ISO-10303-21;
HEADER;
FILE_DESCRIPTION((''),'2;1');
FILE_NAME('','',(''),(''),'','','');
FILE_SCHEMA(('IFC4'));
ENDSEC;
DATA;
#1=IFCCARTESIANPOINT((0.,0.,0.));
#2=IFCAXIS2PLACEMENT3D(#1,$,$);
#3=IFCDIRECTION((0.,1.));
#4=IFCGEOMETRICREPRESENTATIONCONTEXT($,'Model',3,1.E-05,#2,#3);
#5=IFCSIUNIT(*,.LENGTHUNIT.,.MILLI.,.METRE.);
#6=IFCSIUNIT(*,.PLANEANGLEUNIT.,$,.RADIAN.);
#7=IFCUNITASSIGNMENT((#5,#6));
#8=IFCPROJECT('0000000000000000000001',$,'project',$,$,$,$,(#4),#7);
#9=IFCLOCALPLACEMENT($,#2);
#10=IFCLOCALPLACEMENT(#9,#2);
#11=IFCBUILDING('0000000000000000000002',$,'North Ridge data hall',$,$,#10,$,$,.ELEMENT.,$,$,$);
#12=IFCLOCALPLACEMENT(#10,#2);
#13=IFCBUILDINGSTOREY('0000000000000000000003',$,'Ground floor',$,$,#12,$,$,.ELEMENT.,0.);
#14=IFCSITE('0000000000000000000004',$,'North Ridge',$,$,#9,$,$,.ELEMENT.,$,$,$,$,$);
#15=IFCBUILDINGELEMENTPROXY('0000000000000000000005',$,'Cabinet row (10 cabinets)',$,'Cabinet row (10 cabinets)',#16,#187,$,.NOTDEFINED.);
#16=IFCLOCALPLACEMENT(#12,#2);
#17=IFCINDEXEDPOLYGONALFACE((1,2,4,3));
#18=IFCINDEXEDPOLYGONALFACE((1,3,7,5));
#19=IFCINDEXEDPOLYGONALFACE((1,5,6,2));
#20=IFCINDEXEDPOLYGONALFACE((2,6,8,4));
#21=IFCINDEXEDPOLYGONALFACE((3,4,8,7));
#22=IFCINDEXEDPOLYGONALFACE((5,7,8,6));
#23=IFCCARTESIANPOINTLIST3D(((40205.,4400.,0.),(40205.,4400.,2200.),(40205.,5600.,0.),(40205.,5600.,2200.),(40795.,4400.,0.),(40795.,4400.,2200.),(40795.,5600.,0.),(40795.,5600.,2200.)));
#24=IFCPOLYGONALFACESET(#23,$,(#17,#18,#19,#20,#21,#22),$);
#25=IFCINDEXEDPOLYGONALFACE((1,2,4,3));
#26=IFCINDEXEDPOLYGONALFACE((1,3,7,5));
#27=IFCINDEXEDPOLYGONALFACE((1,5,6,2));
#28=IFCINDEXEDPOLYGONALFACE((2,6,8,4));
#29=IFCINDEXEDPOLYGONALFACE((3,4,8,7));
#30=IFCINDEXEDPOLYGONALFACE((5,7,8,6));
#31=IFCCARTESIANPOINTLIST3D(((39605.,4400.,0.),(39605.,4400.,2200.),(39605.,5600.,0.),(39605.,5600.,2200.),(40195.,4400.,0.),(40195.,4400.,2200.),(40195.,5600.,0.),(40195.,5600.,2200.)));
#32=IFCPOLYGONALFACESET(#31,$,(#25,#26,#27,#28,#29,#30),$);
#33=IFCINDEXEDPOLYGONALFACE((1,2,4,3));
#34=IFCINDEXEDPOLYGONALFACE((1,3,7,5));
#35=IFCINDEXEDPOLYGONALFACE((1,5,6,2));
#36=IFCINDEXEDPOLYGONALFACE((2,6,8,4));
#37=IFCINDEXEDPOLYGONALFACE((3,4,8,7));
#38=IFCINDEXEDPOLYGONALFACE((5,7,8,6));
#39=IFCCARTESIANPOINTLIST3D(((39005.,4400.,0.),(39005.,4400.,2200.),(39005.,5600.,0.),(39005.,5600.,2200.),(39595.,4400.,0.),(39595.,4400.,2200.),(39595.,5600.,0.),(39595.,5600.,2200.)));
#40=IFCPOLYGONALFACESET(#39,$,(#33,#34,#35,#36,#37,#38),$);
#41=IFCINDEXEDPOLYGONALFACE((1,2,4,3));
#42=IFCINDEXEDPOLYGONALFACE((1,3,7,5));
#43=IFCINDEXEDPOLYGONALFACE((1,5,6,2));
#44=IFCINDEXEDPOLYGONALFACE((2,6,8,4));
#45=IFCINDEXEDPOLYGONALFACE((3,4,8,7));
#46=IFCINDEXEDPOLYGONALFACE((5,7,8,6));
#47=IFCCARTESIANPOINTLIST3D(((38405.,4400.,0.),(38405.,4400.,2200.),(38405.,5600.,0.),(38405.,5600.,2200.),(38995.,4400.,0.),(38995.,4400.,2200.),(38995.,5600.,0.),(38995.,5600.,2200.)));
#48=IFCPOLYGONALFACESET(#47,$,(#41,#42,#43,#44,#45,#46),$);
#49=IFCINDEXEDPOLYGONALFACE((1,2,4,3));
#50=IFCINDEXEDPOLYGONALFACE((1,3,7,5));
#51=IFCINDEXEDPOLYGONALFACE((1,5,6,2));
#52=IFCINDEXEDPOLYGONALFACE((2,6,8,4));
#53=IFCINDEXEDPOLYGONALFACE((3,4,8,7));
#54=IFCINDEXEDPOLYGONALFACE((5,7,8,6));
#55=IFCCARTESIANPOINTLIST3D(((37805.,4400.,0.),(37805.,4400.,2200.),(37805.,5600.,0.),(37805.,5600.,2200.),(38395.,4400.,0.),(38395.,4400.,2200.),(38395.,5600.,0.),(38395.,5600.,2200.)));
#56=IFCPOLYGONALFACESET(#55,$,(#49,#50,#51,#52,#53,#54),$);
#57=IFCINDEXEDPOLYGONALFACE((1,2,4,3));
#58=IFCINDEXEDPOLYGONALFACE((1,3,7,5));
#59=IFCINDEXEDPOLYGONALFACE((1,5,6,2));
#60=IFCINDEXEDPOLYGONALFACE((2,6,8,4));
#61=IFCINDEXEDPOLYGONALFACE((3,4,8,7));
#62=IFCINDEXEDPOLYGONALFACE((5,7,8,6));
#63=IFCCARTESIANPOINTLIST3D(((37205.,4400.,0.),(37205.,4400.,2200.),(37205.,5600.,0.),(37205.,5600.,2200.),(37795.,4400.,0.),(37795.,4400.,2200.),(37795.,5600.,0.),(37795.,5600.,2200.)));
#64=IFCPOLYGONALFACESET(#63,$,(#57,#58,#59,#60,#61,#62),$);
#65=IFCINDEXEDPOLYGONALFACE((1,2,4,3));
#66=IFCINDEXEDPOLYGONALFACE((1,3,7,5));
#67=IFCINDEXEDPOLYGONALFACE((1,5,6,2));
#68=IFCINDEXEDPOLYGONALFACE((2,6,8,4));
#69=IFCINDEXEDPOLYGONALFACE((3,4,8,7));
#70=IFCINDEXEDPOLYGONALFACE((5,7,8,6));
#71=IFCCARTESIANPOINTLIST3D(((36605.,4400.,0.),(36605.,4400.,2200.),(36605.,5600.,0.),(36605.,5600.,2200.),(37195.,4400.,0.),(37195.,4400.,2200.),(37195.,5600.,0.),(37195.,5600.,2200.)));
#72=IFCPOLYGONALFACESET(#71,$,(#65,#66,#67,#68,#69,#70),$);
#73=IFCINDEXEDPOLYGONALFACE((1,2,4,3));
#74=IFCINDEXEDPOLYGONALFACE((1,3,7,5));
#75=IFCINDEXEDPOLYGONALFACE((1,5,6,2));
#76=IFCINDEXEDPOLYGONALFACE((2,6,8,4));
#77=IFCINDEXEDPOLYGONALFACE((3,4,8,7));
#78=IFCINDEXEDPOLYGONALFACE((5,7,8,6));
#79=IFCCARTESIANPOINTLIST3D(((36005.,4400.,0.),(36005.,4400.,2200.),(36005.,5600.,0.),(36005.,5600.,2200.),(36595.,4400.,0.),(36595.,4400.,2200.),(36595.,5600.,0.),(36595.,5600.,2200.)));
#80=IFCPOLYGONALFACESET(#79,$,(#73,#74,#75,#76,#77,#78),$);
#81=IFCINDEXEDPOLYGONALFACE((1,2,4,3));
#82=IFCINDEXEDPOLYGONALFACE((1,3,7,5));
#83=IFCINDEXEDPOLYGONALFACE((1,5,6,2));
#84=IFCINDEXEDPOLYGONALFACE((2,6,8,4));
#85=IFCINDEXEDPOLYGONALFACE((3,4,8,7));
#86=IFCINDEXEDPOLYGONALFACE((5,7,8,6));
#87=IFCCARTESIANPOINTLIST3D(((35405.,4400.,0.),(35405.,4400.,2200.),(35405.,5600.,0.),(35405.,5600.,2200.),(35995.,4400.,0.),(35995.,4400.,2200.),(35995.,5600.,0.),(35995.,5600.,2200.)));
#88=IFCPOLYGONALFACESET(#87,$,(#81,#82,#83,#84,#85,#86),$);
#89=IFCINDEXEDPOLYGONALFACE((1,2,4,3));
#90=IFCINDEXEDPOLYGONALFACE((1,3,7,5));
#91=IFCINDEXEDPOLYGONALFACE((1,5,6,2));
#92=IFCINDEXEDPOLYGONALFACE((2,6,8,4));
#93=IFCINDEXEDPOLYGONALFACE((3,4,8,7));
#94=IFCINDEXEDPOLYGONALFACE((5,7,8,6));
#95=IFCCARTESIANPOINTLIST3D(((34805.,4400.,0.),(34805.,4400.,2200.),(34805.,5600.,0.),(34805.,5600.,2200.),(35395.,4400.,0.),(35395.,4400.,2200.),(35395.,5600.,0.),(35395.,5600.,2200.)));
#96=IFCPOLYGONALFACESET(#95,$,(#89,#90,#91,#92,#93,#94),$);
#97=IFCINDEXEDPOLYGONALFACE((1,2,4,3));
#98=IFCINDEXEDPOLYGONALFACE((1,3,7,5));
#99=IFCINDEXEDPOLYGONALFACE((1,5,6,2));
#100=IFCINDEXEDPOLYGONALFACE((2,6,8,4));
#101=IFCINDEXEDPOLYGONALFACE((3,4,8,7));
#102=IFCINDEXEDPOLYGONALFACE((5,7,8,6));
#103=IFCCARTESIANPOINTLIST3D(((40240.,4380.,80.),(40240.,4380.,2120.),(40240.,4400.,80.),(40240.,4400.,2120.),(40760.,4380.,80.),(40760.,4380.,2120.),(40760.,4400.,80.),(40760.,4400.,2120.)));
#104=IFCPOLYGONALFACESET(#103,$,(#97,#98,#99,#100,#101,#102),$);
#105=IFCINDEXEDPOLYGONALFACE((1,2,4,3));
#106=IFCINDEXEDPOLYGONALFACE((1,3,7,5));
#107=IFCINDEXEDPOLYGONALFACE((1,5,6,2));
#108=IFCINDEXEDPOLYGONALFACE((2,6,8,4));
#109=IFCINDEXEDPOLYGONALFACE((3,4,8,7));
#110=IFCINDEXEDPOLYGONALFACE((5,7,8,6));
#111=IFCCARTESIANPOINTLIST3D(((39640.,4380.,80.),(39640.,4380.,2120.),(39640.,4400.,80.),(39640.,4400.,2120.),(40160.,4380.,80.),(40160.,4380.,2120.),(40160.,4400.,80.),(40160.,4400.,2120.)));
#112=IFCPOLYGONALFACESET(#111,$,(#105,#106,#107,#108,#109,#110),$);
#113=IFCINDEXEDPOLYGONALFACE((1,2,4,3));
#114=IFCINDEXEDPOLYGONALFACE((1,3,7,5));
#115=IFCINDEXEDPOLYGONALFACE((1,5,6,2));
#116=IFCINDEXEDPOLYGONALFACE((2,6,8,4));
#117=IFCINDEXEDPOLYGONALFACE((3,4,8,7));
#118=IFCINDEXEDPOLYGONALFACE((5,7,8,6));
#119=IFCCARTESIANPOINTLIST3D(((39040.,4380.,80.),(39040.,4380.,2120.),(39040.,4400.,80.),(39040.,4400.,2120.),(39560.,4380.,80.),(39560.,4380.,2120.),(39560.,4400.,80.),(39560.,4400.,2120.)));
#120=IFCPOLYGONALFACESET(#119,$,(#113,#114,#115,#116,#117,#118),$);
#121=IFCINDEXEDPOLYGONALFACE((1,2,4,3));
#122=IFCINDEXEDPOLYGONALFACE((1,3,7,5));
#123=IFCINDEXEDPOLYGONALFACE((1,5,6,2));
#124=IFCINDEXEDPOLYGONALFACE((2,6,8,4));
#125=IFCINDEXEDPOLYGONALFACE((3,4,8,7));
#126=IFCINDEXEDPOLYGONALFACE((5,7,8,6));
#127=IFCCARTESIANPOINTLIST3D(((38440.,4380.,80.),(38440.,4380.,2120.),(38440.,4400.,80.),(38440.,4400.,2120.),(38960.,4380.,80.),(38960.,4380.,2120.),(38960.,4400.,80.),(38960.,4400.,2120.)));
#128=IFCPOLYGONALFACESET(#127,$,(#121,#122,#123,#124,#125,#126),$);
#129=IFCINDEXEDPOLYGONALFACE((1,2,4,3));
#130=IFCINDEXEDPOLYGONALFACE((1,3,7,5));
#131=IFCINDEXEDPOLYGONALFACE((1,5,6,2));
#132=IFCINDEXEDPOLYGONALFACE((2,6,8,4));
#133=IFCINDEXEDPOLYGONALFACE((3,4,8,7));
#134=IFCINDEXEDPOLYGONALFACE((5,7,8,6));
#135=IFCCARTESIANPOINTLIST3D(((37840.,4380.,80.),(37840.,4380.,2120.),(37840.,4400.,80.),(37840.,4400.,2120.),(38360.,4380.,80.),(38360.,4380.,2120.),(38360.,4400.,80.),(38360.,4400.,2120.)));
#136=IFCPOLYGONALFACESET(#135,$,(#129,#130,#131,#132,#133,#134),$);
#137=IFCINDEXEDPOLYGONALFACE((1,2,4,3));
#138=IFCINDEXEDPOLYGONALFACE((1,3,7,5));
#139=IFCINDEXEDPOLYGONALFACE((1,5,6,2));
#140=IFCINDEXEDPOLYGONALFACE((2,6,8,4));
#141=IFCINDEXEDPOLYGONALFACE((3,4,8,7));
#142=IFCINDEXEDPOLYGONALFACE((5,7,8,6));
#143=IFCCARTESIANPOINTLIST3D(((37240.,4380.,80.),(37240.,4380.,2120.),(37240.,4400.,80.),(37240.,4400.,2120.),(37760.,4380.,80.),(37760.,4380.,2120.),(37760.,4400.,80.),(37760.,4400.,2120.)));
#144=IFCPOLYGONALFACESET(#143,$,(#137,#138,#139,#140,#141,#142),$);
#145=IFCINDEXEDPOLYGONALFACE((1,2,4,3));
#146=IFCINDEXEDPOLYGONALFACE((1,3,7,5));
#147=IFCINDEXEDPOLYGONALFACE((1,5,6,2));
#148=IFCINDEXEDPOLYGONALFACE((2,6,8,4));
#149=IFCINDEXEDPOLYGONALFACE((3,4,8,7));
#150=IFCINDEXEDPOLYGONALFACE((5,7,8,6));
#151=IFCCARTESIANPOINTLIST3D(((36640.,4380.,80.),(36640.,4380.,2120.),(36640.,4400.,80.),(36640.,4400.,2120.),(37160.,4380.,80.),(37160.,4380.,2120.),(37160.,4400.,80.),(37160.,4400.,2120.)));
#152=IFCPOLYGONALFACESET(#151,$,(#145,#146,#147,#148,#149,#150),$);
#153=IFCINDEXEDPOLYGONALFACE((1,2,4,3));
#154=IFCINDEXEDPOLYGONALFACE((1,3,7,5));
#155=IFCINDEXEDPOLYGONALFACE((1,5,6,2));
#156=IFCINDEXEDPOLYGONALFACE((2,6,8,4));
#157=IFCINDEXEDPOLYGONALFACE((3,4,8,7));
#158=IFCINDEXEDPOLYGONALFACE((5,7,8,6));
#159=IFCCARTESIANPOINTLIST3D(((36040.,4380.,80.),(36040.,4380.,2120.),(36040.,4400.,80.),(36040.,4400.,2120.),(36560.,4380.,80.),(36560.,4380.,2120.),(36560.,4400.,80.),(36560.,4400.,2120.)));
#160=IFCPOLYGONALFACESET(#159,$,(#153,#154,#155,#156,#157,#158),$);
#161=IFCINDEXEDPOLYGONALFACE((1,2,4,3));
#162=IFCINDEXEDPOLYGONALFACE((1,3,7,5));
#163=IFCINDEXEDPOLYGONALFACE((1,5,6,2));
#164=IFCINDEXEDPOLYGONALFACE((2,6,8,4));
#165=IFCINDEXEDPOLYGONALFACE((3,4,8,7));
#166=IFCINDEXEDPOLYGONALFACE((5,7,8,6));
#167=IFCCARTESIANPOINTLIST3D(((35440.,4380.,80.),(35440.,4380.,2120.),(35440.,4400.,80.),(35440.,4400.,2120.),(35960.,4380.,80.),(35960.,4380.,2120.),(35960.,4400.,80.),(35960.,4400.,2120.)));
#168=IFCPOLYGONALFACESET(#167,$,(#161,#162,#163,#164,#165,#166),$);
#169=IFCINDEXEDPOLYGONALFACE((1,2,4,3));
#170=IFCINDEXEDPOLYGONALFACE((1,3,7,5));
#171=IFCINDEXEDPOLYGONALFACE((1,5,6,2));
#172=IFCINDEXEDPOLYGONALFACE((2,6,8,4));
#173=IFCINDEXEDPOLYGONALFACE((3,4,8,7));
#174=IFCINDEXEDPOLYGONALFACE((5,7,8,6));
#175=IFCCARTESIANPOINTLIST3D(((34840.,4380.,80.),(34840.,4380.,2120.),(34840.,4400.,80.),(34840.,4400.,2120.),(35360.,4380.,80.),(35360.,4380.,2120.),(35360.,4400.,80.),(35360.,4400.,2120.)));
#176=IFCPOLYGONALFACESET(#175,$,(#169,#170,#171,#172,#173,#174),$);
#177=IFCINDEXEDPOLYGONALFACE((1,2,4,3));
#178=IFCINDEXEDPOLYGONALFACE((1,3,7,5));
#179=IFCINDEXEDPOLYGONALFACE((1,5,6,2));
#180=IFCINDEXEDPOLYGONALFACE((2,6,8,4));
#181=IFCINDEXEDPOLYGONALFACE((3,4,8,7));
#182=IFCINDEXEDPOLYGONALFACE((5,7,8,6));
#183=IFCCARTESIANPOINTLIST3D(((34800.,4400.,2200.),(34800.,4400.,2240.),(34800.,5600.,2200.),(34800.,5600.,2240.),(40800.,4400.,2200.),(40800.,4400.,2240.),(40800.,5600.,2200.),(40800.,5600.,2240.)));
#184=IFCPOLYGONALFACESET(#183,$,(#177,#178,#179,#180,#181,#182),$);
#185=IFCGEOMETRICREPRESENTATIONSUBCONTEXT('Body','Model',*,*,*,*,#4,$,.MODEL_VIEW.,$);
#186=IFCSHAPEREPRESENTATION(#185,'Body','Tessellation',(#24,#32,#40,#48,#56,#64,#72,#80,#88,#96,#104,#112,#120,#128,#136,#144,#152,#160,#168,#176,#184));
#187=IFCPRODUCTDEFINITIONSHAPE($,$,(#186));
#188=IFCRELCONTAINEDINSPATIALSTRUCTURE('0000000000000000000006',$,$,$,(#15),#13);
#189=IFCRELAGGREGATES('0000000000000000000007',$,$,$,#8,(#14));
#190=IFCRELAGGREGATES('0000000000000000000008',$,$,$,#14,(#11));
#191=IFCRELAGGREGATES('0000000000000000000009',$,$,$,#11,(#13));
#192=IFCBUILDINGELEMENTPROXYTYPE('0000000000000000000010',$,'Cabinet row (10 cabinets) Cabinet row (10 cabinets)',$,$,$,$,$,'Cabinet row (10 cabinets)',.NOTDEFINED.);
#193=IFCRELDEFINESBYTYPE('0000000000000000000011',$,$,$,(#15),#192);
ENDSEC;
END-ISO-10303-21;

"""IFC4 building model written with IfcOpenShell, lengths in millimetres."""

from ifc_helpers import new_model, si_unit, direction, frame, origin, place, context, subcontext, project, spatial, polyline, outline, extrude, source, transform, mapped, type_object, type_shapes, element, save


model = new_model("IFC4")

# Units and contexts
model_context = context("Model", 3, precision=1e-05, world=origin(), true_north=direction((0.0, 1.0)))
body_context = subcontext(model_context, "Body", "Model", "MODEL_VIEW")
ifc_project = project(units=[si_unit("LENGTHUNIT", "METRE", prefix="MILLI"), si_unit("PLANEANGLEUNIT", "RADIAN")], contexts=[model_context])

# Site, building, storey
site_placement = place(None, origin())
site = spatial("IfcSite", under=ifc_project, at=site_placement, Name="North Ridge", CompositionType="ELEMENT")
building_placement = place(site_placement, origin())
building = spatial("IfcBuilding", under=site, at=building_placement, Name="North Ridge data hall", CompositionType="ELEMENT")
storey_placement = place(building_placement, origin())
storey = spatial("IfcBuildingStorey", under=building, at=storey_placement, Name="Ground floor", CompositionType="ELEMENT", Elevation=0.0)

# Building element proxy
building_element_proxy_type_1 = type_object("IfcBuildingElementProxyType", Name="Cabinet row (10 cabinets) Cabinet row (10 cabinets)", ElementType="Cabinet row (10 cabinets)", PredefinedType="NOTDEFINED")
shared_shape_1 = source(origin(), body_context, "Body", "SweptSolid", [
    extrude(outline(polyline([(5.0, 0.0), (595.0, 0.0), (595.0, 1200.0), (5.0, 1200.0), (5.0, 0.0)])), origin(), (0.0, 0.0, 1.0), 2200.0),
    extrude(outline(polyline([(605.0, 0.0), (1195.0, 0.0), (1195.0, 1200.0), (605.0, 1200.0), (605.0, 0.0)])), origin(), (0.0, 0.0, 1.0), 2200.0),
    extrude(outline(polyline([(1205.0, 0.0), (1795.0, 0.0), (1795.0, 1200.0), (1205.0, 1200.0), (1205.0, 0.0)])), origin(), (0.0, 0.0, 1.0), 2200.0),
    extrude(outline(polyline([(1805.0, 0.0), (2395.0, 0.0), (2395.0, 1200.0), (1805.0, 1200.0), (1805.0, 0.0)])), origin(), (0.0, 0.0, 1.0), 2200.0),
    extrude(outline(polyline([(2405.0, 0.0), (2995.0, 0.0), (2995.0, 1200.0), (2405.0, 1200.0), (2405.0, 0.0)])), origin(), (0.0, 0.0, 1.0), 2200.0),
    extrude(outline(polyline([(3005.0, 0.0), (3595.0, 0.0), (3595.0, 1200.0), (3005.0, 1200.0), (3005.0, 0.0)])), origin(), (0.0, 0.0, 1.0), 2200.0),
    extrude(outline(polyline([(3605.0, 0.0), (4195.0, 0.0), (4195.0, 1200.0), (3605.0, 1200.0), (3605.0, 0.0)])), origin(), (0.0, 0.0, 1.0), 2200.0),
    extrude(outline(polyline([(4205.0, 0.0), (4795.0, 0.0), (4795.0, 1200.0), (4205.0, 1200.0), (4205.0, 0.0)])), origin(), (0.0, 0.0, 1.0), 2200.0),
    extrude(outline(polyline([(4805.0, 0.0), (5395.0, 0.0), (5395.0, 1200.0), (4805.0, 1200.0), (4805.0, 0.0)])), origin(), (0.0, 0.0, 1.0), 2200.0),
    extrude(outline(polyline([(5405.0, 0.0), (5995.0, 0.0), (5995.0, 1200.0), (5405.0, 1200.0), (5405.0, 0.0)])), origin(), (0.0, 0.0, 1.0), 2200.0),
    extrude(outline(polyline([(40.0, 1200.0), (560.0, 1200.0), (560.0, 1220.0), (40.0, 1220.0), (40.0, 1200.0)])), frame((0.0, 0.0, 80.0)), (0.0, 0.0, 1.0), 2040.0),
    extrude(outline(polyline([(640.0, 1200.0), (1160.0, 1200.0), (1160.0, 1220.0), (640.0, 1220.0), (640.0, 1200.0)])), frame((0.0, 0.0, 80.0)), (0.0, 0.0, 1.0), 2040.0),
    extrude(outline(polyline([(1240.0, 1200.0), (1760.0, 1200.0), (1760.0, 1220.0), (1240.0, 1220.0), (1240.0, 1200.0)])), frame((0.0, 0.0, 80.0)), (0.0, 0.0, 1.0), 2040.0),
    extrude(outline(polyline([(1840.0, 1200.0), (2360.0, 1200.0), (2360.0, 1220.0), (1840.0, 1220.0), (1840.0, 1200.0)])), frame((0.0, 0.0, 80.0)), (0.0, 0.0, 1.0), 2040.0),
    extrude(outline(polyline([(2440.0, 1200.0), (2960.0, 1200.0), (2960.0, 1220.0), (2440.0, 1220.0), (2440.0, 1200.0)])), frame((0.0, 0.0, 80.0)), (0.0, 0.0, 1.0), 2040.0),
    extrude(outline(polyline([(3040.0, 1200.0), (3560.0, 1200.0), (3560.0, 1220.0), (3040.0, 1220.0), (3040.0, 1200.0)])), frame((0.0, 0.0, 80.0)), (0.0, 0.0, 1.0), 2040.0),
    extrude(outline(polyline([(3640.0, 1200.0), (4160.0, 1200.0), (4160.0, 1220.0), (3640.0, 1220.0), (3640.0, 1200.0)])), frame((0.0, 0.0, 80.0)), (0.0, 0.0, 1.0), 2040.0),
    extrude(outline(polyline([(4240.0, 1200.0), (4760.0, 1200.0), (4760.0, 1220.0), (4240.0, 1220.0), (4240.0, 1200.0)])), frame((0.0, 0.0, 80.0)), (0.0, 0.0, 1.0), 2040.0),
    extrude(outline(polyline([(4840.0, 1200.0), (5360.0, 1200.0), (5360.0, 1220.0), (4840.0, 1220.0), (4840.0, 1200.0)])), frame((0.0, 0.0, 80.0)), (0.0, 0.0, 1.0), 2040.0),
    extrude(outline(polyline([(5440.0, 1200.0), (5960.0, 1200.0), (5960.0, 1220.0), (5440.0, 1220.0), (5440.0, 1200.0)])), frame((0.0, 0.0, 80.0)), (0.0, 0.0, 1.0), 2040.0),
    extrude(outline(polyline([(0.0, 0.0), (6000.0, 0.0), (6000.0, 1200.0), (0.0, 1200.0), (0.0, 0.0)])), frame((0.0, 0.0, 2200.0)), (0.0, 0.0, 1.0), 40.0),
])
type_shapes(building_element_proxy_type_1, [shared_shape_1])
for number, where, z_axis, x_axis, name in (
    (1, (40800.0, 5600.0, 0.0), (0.0, 0.0, 1.0), (-1.0, 0.0, 0.0), "Cabinet row (10 cabinets)"),
):
    element("IfcBuildingElementProxy", number, at=place(storey_placement, frame(where, z_axis=z_axis, x_axis=x_axis)), inside=storey, type_object=building_element_proxy_type_1, Name=name, ObjectType="Cabinet row (10 cabinets)", PredefinedType="NOTDEFINED", context=body_context, shape_type="MappedRepresentation", body=[
        mapped(shared_shape_1, transform((0.0, 0.0, 0.0))),
    ])

save(model, "model.ifc")
